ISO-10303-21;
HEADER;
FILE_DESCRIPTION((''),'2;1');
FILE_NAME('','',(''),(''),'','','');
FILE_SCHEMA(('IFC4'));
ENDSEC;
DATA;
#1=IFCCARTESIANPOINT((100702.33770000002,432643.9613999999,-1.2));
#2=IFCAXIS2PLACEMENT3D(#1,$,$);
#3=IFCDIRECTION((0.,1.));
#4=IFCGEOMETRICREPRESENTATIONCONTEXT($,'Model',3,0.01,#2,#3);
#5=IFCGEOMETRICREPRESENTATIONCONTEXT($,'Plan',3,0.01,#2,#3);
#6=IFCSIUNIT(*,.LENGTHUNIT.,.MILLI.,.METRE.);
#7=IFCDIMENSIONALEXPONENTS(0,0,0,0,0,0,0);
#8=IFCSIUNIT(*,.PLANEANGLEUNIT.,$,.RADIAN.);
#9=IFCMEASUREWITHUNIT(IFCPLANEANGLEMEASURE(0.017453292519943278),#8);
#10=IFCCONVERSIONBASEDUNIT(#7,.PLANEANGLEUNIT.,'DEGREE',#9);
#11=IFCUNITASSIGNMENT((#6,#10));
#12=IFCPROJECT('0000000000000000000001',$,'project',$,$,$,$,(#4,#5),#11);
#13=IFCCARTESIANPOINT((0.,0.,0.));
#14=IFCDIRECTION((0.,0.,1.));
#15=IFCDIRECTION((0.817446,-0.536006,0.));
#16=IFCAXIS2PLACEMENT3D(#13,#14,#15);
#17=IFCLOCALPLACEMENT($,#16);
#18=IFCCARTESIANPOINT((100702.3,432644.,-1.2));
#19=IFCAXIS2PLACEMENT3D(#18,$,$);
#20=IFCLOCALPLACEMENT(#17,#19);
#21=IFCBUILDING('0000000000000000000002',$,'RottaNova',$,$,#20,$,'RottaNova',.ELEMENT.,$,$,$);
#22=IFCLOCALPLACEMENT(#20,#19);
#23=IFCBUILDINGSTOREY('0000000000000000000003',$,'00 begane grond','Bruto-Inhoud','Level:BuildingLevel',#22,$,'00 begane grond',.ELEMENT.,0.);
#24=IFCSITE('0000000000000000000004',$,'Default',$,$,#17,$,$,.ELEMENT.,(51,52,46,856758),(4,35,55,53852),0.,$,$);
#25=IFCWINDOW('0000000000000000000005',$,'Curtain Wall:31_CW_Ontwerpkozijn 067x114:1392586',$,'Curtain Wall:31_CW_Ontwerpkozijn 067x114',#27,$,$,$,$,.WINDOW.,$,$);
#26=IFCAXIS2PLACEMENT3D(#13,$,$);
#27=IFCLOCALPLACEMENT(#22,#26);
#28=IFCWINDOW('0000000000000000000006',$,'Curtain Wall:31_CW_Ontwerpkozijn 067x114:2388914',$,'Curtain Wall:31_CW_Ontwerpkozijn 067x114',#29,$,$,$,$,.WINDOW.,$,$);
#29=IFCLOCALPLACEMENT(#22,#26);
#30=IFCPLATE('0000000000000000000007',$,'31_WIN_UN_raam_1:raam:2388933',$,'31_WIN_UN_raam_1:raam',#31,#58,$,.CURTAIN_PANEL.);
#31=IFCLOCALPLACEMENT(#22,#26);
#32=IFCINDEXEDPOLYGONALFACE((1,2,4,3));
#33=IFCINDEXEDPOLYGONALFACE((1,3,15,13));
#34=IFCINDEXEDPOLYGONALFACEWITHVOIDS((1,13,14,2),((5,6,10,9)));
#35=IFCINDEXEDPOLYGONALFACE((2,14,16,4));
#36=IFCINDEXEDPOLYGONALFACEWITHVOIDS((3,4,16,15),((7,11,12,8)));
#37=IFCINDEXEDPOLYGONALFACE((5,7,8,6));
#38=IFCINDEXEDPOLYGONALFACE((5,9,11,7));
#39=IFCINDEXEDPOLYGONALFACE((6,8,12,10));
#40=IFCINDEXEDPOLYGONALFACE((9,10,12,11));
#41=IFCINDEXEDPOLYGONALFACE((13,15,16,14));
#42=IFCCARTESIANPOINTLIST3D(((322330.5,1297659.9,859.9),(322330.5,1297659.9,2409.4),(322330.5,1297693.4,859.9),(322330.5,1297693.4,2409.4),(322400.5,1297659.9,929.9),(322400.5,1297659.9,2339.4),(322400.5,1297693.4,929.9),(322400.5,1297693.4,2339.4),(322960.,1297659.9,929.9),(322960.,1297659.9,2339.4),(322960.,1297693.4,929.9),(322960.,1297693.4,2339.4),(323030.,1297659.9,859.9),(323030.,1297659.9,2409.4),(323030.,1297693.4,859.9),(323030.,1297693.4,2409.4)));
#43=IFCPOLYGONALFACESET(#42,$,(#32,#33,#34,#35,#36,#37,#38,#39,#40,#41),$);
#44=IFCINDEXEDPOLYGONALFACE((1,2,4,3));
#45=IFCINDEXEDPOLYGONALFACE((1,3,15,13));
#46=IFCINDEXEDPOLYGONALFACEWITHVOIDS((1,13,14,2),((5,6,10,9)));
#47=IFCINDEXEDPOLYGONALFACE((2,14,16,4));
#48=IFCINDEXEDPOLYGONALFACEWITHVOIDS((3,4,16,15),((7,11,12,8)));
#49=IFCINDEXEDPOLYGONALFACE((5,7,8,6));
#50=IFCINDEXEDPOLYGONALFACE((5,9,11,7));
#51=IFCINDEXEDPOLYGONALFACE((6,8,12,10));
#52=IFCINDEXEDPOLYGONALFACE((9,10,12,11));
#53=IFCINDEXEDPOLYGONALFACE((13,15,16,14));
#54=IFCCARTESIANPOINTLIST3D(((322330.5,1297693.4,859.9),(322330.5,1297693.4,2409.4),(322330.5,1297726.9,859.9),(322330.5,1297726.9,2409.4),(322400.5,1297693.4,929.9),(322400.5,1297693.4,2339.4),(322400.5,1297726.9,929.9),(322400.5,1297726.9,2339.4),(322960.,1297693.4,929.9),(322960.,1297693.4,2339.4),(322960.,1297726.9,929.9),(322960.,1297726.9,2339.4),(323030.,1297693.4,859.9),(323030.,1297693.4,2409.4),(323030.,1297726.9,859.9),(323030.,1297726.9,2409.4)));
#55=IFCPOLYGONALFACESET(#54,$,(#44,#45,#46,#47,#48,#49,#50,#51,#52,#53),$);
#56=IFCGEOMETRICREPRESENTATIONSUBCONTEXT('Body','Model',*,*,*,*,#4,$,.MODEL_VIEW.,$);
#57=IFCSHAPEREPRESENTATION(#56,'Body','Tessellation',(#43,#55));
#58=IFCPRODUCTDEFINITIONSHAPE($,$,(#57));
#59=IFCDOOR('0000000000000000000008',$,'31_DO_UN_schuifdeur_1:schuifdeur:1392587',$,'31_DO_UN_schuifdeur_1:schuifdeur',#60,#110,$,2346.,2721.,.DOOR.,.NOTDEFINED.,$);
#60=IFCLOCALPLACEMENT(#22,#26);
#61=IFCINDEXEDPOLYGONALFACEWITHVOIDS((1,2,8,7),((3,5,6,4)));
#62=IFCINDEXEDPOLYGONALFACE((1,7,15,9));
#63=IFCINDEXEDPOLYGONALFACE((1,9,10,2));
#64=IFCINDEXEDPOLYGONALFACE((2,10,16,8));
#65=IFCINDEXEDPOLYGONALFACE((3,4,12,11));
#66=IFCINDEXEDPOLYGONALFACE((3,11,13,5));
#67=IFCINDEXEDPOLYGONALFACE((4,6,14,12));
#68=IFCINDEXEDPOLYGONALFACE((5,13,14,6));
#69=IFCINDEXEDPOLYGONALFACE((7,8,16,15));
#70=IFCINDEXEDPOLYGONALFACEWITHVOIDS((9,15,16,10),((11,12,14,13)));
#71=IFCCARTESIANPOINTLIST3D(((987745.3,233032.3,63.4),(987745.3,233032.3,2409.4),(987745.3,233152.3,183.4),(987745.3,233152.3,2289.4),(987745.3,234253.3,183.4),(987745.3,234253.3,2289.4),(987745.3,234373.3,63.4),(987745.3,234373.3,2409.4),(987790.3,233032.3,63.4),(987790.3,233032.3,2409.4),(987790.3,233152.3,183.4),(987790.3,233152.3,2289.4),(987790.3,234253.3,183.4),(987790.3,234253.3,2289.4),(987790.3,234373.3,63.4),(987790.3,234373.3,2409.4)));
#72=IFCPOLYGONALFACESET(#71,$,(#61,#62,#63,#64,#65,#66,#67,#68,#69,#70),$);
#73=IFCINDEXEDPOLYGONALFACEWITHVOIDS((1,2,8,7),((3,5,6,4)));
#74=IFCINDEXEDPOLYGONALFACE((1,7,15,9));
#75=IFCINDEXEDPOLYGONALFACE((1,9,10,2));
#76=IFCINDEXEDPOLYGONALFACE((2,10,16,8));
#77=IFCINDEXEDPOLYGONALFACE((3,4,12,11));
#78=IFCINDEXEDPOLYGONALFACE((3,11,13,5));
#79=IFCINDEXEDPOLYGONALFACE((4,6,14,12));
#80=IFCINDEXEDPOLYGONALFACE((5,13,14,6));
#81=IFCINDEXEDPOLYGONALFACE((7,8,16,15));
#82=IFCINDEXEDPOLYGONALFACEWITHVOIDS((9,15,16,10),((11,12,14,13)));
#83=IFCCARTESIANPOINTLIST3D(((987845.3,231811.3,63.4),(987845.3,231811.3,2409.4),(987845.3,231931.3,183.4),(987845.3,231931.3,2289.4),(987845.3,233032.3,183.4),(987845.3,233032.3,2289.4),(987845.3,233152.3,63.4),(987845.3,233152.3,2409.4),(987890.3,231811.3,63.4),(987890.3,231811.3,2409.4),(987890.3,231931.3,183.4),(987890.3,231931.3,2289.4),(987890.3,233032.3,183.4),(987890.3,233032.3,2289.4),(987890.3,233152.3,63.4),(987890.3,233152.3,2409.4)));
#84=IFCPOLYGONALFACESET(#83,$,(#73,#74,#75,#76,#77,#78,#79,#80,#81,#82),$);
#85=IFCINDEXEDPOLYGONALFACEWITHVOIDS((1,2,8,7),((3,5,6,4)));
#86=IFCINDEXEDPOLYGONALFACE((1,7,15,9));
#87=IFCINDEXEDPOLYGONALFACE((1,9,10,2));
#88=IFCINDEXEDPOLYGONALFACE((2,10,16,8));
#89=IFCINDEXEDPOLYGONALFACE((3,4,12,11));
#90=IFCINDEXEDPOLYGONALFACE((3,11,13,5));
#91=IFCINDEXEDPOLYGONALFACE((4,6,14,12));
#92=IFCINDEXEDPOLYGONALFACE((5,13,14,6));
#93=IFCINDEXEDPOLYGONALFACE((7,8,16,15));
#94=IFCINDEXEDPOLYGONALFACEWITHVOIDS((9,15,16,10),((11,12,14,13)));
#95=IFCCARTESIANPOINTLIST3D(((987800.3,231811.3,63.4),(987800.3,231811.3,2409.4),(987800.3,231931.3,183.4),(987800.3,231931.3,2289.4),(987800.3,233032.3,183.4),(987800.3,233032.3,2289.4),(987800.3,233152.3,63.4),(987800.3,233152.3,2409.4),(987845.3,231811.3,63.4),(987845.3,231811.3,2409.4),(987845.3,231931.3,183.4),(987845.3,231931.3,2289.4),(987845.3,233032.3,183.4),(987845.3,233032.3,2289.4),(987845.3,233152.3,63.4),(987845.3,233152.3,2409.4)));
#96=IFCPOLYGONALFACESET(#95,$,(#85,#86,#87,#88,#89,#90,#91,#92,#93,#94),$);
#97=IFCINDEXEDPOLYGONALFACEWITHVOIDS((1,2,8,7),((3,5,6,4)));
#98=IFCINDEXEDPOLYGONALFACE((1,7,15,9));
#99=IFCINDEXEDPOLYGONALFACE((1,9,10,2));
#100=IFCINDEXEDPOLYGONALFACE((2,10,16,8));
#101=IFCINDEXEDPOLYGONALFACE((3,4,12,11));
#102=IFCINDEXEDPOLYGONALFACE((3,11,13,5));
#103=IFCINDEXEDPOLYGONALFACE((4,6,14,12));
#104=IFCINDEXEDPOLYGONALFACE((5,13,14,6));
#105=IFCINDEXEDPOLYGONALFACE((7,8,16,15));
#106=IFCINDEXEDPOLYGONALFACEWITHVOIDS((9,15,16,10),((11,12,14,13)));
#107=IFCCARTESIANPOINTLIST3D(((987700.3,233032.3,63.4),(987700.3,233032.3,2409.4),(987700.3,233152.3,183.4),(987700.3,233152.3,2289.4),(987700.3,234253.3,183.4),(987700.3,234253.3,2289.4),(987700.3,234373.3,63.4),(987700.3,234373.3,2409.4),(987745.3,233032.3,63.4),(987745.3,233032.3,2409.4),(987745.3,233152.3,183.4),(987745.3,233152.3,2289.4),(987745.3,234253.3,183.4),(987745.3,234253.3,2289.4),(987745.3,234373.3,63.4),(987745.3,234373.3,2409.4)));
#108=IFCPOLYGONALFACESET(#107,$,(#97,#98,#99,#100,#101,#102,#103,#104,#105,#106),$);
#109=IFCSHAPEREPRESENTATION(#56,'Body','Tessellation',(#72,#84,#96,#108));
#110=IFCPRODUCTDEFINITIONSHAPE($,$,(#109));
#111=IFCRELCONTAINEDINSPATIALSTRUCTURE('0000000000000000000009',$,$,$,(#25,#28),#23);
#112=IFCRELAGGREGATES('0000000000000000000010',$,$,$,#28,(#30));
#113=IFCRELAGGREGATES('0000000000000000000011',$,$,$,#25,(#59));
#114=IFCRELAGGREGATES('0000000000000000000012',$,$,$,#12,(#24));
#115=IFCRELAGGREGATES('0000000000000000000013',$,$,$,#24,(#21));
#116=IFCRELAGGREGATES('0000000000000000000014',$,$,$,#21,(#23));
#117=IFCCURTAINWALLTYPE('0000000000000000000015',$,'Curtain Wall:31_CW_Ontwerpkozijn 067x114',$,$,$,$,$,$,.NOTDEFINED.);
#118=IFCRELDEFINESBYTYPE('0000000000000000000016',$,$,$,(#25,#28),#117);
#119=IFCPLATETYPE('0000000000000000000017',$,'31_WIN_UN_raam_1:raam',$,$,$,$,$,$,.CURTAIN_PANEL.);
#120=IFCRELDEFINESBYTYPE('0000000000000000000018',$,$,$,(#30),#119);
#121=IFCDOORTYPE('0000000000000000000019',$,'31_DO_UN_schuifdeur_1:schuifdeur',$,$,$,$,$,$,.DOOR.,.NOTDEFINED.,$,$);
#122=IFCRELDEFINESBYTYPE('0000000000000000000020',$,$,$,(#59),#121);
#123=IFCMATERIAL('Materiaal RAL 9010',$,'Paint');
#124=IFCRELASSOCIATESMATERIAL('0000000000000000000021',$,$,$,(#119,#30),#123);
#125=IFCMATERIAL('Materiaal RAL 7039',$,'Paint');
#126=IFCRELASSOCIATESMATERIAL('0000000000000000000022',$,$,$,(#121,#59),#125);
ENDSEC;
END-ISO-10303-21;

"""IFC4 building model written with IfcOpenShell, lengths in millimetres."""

from ifc_helpers import new_model, entity, si_unit, converted_unit, direction, frame, place, context, subcontext, project, spatial, indexed_curve, outline, extrude, source, transform, mapped, material, type_object, type_shapes, element, aggregate, save


model = new_model("IFC4")

# Units and contexts
model_context = context("Model", 3, precision=0.01, world=frame((100702.33770000002, 432643.9613999999, -1.2)), true_north=direction((0.0, 1.0)))
plan_context = context("Plan", 3, precision=0.01, world=frame((100702.33770000002, 432643.9613999999, -1.2)), true_north=direction((0.0, 1.0)))
body_context = subcontext(model_context, "Body", "Model", "MODEL_VIEW")
ifc_project = project(units=[si_unit("LENGTHUNIT", "METRE", prefix="MILLI"), converted_unit("PLANEANGLEUNIT", "DEGREE", entity("IfcPlaneAngleMeasure", 0.017453292519943278), si_unit("PLANEANGLEUNIT", "RADIAN"), dimensions=[0, 0, 0, 0, 0, 0, 0])], contexts=[model_context, plan_context])

# Site, building, storey
site_placement = place(None, frame((0.0, 0.0, 0.0), z_axis=(0.0, 0.0, 1.0), x_axis=(0.817446, -0.536006, 0.0)))
site = spatial("IfcSite", under=ifc_project, at=site_placement, Name="Default", CompositionType="ELEMENT", RefLatitude=(51, 52, 46, 856758), RefLongitude=(4, 35, 55, 53852), RefElevation=0.0)
building_placement = place(site_placement, frame((100702.3, 432644.0, -1.2)))
building = spatial("IfcBuilding", under=site, at=building_placement, Name="RottaNova", LongName="RottaNova", CompositionType="ELEMENT")
storey_placement = place(building_placement, frame((100702.3, 432644.0, -1.2)))
storey = spatial("IfcBuildingStorey", under=building, at=storey_placement, Name="00 begane grond", Description="Bruto-Inhoud", ObjectType="Level:BuildingLevel", LongName="00 begane grond", CompositionType="ELEMENT", Elevation=0.0)

# Window
curtain_wall_type = type_object("IfcCurtainWallType", Name="Curtain Wall:31_CW_Ontwerpkozijn 067x114", PredefinedType="NOTDEFINED")
window_1_placement = place(storey_placement, frame((100702.3, 432644.0, -1.2)))
window_1 = element("IfcWindow", 1, at=window_1_placement, inside=storey, type_object=curtain_wall_type, Name="Curtain Wall:31_CW_Ontwerpkozijn 067x114:1392586", ObjectType="Curtain Wall:31_CW_Ontwerpkozijn 067x114", PredefinedType="WINDOW")
ifc_material_1 = material(Name="Materiaal RAL 7039", Category="Paint")

# Window
window_2_placement = place(storey_placement, frame((100702.3, 432644.0, -1.2)))
window_2 = element("IfcWindow", 2, at=window_2_placement, inside=storey, type_object=curtain_wall_type, Name="Curtain Wall:31_CW_Ontwerpkozijn 067x114:2388914", ObjectType="Curtain Wall:31_CW_Ontwerpkozijn 067x114", PredefinedType="WINDOW")

# Plate
ifc_material_2 = material(Name="Materiaal RAL 9010", Category="Paint")
plate_type_1 = type_object("IfcPlateType", Name="31_WIN_UN_raam_1:raam", PredefinedType="CURTAIN_PANEL", material=ifc_material_2)
shared_shape_1 = source(frame((100702.3, 432644.0, -1.2)), body_context, "Body", "SweptSolid", [
    extrude(outline(indexed_curve([(-349.7, -774.8), (349.7, -774.8), (349.7, 774.8), (-349.7, 774.8), (-349.7, -774.8)], self_intersect=False), holes=[indexed_curve([(-279.7, 704.8), (279.7, 704.8), (279.7, -704.8), (-279.7, -704.8), (-279.7, 704.8)], self_intersect=False)]), frame((0.0, -92.0, 774.8), z_axis=(0.0, 1.0, 0.0), x_axis=(1.0, 0.0, 0.0)), (0.0, 0.0, 1.0), 33.5),
    extrude(outline(indexed_curve([(-349.7, -774.8), (349.7, -774.8), (349.7, 774.8), (-349.7, 774.8), (-349.7, -774.8)], self_intersect=False), holes=[indexed_curve([(-279.7, 704.7), (279.7, 704.7), (279.7, -704.8), (-279.7, -704.8), (-279.7, 704.7)], self_intersect=False)]), frame((0.0, -58.5, 774.8), z_axis=(0.0, 1.0, 0.0), x_axis=(1.0, 0.0, 0.0)), (0.0, 0.0, 1.0), 33.5),
])
type_shapes(plate_type_1, [shared_shape_1])
plate_1_placement = place(window_2_placement, frame((20573.3, -180.0, 863.5)))
plate_1 = element("IfcPlate", 3, at=plate_1_placement, type_object=plate_type_1, material=ifc_material_2, Name="31_WIN_UN_raam_1:raam:2388933", ObjectType="31_WIN_UN_raam_1:raam", PredefinedType="CURTAIN_PANEL", context=body_context, shape_type="MappedRepresentation", body=[
    mapped(shared_shape_1, transform((100702.3, 432644.0, -1.2), scale=1.0)),
])
aggregate(window_2, [plate_1])

# Door
door_type = type_object("IfcDoorType", Name="31_DO_UN_schuifdeur_1:schuifdeur", OperationType="NOTDEFINED", PredefinedType="DOOR", material=ifc_material_1)
shared_shape_2 = source(frame((100702.3, 432644.0, -1.2)), body_context, "Body", "SweptSolid", [
    extrude(outline(indexed_curve([(-670.5, -1173.0), (670.5, -1173.0), (670.5, 1173.0), (-670.5, 1173.0), (-670.5, -1173.0)], self_intersect=False), holes=[indexed_curve([(-550.5, -1053.0), (-550.5, 1053.0), (550.5, 1053.0), (550.5, -1053.0), (-550.5, -1053.0)], self_intersect=False)]), frame((-610.5, 90.0, 1173.0), z_axis=(0.0, -1.0, 0.0), x_axis=(-1.0, 0.0, 0.0)), (0.0, 0.0, 1.0), 45.0),
    extrude(outline(indexed_curve([(-670.5, -1173.0), (670.5, -1173.0), (670.5, 1173.0), (-670.5, 1173.0), (-670.5, -1173.0)], self_intersect=False), holes=[indexed_curve([(-550.5, -1053.0), (-550.5, 1053.0), (550.5, 1053.0), (550.5, -1053.0), (-550.5, -1053.0)], self_intersect=False)]), frame((610.5, 190.0, 1173.0), z_axis=(0.0, -1.0, 0.0), x_axis=(-1.0, 0.0, 0.0)), (0.0, 0.0, 1.0), 45.0),
    extrude(outline(indexed_curve([(-670.5, -1173.0), (670.5, -1173.0), (670.5, 1173.0), (-670.5, 1173.0), (-670.5, -1173.0)], self_intersect=False), holes=[indexed_curve([(-550.5, -1053.0), (-550.5, 1053.0), (550.5, 1053.0), (550.5, -1053.0), (-550.5, -1053.0)], self_intersect=False)]), frame((610.5, 145.0, 1173.0), z_axis=(0.0, -1.0, 0.0), x_axis=(-1.0, 0.0, 0.0)), (0.0, 0.0, 1.0), 45.0),
    extrude(outline(indexed_curve([(-670.5, -1173.0), (670.5, -1173.0), (670.5, 1173.0), (-670.5, 1173.0), (-670.5, -1173.0)], self_intersect=False), holes=[indexed_curve([(-550.5, -1053.0), (-550.5, 1053.0), (550.5, 1053.0), (550.5, -1053.0), (-550.5, -1053.0)], self_intersect=False)]), frame((-610.5, 45.0, 1173.0), z_axis=(0.0, -1.0, 0.0), x_axis=(-1.0, 0.0, 0.0)), (0.0, 0.0, 1.0), 45.0),
])
type_shapes(door_type, [shared_shape_2])
door_placement = place(window_1_placement, frame((21710.0, 1853.0, 67.0), z_axis=(0.0, 0.0, 1.0), x_axis=(0.0, -1.0, 0.0)))
door = element("IfcDoor", 4, at=door_placement, type_object=door_type, material=ifc_material_1, Name="31_DO_UN_schuifdeur_1:schuifdeur:1392587", ObjectType="31_DO_UN_schuifdeur_1:schuifdeur", OperationType="NOTDEFINED", OverallHeight=2346.0, OverallWidth=2721.0, PredefinedType="DOOR", context=body_context, shape_type="MappedRepresentation", body=[
    mapped(shared_shape_2, transform((100702.3, 432644.0, -1.2), scale=1.0)),
])
aggregate(window_1, [door])

save(model, "model.ifc")
